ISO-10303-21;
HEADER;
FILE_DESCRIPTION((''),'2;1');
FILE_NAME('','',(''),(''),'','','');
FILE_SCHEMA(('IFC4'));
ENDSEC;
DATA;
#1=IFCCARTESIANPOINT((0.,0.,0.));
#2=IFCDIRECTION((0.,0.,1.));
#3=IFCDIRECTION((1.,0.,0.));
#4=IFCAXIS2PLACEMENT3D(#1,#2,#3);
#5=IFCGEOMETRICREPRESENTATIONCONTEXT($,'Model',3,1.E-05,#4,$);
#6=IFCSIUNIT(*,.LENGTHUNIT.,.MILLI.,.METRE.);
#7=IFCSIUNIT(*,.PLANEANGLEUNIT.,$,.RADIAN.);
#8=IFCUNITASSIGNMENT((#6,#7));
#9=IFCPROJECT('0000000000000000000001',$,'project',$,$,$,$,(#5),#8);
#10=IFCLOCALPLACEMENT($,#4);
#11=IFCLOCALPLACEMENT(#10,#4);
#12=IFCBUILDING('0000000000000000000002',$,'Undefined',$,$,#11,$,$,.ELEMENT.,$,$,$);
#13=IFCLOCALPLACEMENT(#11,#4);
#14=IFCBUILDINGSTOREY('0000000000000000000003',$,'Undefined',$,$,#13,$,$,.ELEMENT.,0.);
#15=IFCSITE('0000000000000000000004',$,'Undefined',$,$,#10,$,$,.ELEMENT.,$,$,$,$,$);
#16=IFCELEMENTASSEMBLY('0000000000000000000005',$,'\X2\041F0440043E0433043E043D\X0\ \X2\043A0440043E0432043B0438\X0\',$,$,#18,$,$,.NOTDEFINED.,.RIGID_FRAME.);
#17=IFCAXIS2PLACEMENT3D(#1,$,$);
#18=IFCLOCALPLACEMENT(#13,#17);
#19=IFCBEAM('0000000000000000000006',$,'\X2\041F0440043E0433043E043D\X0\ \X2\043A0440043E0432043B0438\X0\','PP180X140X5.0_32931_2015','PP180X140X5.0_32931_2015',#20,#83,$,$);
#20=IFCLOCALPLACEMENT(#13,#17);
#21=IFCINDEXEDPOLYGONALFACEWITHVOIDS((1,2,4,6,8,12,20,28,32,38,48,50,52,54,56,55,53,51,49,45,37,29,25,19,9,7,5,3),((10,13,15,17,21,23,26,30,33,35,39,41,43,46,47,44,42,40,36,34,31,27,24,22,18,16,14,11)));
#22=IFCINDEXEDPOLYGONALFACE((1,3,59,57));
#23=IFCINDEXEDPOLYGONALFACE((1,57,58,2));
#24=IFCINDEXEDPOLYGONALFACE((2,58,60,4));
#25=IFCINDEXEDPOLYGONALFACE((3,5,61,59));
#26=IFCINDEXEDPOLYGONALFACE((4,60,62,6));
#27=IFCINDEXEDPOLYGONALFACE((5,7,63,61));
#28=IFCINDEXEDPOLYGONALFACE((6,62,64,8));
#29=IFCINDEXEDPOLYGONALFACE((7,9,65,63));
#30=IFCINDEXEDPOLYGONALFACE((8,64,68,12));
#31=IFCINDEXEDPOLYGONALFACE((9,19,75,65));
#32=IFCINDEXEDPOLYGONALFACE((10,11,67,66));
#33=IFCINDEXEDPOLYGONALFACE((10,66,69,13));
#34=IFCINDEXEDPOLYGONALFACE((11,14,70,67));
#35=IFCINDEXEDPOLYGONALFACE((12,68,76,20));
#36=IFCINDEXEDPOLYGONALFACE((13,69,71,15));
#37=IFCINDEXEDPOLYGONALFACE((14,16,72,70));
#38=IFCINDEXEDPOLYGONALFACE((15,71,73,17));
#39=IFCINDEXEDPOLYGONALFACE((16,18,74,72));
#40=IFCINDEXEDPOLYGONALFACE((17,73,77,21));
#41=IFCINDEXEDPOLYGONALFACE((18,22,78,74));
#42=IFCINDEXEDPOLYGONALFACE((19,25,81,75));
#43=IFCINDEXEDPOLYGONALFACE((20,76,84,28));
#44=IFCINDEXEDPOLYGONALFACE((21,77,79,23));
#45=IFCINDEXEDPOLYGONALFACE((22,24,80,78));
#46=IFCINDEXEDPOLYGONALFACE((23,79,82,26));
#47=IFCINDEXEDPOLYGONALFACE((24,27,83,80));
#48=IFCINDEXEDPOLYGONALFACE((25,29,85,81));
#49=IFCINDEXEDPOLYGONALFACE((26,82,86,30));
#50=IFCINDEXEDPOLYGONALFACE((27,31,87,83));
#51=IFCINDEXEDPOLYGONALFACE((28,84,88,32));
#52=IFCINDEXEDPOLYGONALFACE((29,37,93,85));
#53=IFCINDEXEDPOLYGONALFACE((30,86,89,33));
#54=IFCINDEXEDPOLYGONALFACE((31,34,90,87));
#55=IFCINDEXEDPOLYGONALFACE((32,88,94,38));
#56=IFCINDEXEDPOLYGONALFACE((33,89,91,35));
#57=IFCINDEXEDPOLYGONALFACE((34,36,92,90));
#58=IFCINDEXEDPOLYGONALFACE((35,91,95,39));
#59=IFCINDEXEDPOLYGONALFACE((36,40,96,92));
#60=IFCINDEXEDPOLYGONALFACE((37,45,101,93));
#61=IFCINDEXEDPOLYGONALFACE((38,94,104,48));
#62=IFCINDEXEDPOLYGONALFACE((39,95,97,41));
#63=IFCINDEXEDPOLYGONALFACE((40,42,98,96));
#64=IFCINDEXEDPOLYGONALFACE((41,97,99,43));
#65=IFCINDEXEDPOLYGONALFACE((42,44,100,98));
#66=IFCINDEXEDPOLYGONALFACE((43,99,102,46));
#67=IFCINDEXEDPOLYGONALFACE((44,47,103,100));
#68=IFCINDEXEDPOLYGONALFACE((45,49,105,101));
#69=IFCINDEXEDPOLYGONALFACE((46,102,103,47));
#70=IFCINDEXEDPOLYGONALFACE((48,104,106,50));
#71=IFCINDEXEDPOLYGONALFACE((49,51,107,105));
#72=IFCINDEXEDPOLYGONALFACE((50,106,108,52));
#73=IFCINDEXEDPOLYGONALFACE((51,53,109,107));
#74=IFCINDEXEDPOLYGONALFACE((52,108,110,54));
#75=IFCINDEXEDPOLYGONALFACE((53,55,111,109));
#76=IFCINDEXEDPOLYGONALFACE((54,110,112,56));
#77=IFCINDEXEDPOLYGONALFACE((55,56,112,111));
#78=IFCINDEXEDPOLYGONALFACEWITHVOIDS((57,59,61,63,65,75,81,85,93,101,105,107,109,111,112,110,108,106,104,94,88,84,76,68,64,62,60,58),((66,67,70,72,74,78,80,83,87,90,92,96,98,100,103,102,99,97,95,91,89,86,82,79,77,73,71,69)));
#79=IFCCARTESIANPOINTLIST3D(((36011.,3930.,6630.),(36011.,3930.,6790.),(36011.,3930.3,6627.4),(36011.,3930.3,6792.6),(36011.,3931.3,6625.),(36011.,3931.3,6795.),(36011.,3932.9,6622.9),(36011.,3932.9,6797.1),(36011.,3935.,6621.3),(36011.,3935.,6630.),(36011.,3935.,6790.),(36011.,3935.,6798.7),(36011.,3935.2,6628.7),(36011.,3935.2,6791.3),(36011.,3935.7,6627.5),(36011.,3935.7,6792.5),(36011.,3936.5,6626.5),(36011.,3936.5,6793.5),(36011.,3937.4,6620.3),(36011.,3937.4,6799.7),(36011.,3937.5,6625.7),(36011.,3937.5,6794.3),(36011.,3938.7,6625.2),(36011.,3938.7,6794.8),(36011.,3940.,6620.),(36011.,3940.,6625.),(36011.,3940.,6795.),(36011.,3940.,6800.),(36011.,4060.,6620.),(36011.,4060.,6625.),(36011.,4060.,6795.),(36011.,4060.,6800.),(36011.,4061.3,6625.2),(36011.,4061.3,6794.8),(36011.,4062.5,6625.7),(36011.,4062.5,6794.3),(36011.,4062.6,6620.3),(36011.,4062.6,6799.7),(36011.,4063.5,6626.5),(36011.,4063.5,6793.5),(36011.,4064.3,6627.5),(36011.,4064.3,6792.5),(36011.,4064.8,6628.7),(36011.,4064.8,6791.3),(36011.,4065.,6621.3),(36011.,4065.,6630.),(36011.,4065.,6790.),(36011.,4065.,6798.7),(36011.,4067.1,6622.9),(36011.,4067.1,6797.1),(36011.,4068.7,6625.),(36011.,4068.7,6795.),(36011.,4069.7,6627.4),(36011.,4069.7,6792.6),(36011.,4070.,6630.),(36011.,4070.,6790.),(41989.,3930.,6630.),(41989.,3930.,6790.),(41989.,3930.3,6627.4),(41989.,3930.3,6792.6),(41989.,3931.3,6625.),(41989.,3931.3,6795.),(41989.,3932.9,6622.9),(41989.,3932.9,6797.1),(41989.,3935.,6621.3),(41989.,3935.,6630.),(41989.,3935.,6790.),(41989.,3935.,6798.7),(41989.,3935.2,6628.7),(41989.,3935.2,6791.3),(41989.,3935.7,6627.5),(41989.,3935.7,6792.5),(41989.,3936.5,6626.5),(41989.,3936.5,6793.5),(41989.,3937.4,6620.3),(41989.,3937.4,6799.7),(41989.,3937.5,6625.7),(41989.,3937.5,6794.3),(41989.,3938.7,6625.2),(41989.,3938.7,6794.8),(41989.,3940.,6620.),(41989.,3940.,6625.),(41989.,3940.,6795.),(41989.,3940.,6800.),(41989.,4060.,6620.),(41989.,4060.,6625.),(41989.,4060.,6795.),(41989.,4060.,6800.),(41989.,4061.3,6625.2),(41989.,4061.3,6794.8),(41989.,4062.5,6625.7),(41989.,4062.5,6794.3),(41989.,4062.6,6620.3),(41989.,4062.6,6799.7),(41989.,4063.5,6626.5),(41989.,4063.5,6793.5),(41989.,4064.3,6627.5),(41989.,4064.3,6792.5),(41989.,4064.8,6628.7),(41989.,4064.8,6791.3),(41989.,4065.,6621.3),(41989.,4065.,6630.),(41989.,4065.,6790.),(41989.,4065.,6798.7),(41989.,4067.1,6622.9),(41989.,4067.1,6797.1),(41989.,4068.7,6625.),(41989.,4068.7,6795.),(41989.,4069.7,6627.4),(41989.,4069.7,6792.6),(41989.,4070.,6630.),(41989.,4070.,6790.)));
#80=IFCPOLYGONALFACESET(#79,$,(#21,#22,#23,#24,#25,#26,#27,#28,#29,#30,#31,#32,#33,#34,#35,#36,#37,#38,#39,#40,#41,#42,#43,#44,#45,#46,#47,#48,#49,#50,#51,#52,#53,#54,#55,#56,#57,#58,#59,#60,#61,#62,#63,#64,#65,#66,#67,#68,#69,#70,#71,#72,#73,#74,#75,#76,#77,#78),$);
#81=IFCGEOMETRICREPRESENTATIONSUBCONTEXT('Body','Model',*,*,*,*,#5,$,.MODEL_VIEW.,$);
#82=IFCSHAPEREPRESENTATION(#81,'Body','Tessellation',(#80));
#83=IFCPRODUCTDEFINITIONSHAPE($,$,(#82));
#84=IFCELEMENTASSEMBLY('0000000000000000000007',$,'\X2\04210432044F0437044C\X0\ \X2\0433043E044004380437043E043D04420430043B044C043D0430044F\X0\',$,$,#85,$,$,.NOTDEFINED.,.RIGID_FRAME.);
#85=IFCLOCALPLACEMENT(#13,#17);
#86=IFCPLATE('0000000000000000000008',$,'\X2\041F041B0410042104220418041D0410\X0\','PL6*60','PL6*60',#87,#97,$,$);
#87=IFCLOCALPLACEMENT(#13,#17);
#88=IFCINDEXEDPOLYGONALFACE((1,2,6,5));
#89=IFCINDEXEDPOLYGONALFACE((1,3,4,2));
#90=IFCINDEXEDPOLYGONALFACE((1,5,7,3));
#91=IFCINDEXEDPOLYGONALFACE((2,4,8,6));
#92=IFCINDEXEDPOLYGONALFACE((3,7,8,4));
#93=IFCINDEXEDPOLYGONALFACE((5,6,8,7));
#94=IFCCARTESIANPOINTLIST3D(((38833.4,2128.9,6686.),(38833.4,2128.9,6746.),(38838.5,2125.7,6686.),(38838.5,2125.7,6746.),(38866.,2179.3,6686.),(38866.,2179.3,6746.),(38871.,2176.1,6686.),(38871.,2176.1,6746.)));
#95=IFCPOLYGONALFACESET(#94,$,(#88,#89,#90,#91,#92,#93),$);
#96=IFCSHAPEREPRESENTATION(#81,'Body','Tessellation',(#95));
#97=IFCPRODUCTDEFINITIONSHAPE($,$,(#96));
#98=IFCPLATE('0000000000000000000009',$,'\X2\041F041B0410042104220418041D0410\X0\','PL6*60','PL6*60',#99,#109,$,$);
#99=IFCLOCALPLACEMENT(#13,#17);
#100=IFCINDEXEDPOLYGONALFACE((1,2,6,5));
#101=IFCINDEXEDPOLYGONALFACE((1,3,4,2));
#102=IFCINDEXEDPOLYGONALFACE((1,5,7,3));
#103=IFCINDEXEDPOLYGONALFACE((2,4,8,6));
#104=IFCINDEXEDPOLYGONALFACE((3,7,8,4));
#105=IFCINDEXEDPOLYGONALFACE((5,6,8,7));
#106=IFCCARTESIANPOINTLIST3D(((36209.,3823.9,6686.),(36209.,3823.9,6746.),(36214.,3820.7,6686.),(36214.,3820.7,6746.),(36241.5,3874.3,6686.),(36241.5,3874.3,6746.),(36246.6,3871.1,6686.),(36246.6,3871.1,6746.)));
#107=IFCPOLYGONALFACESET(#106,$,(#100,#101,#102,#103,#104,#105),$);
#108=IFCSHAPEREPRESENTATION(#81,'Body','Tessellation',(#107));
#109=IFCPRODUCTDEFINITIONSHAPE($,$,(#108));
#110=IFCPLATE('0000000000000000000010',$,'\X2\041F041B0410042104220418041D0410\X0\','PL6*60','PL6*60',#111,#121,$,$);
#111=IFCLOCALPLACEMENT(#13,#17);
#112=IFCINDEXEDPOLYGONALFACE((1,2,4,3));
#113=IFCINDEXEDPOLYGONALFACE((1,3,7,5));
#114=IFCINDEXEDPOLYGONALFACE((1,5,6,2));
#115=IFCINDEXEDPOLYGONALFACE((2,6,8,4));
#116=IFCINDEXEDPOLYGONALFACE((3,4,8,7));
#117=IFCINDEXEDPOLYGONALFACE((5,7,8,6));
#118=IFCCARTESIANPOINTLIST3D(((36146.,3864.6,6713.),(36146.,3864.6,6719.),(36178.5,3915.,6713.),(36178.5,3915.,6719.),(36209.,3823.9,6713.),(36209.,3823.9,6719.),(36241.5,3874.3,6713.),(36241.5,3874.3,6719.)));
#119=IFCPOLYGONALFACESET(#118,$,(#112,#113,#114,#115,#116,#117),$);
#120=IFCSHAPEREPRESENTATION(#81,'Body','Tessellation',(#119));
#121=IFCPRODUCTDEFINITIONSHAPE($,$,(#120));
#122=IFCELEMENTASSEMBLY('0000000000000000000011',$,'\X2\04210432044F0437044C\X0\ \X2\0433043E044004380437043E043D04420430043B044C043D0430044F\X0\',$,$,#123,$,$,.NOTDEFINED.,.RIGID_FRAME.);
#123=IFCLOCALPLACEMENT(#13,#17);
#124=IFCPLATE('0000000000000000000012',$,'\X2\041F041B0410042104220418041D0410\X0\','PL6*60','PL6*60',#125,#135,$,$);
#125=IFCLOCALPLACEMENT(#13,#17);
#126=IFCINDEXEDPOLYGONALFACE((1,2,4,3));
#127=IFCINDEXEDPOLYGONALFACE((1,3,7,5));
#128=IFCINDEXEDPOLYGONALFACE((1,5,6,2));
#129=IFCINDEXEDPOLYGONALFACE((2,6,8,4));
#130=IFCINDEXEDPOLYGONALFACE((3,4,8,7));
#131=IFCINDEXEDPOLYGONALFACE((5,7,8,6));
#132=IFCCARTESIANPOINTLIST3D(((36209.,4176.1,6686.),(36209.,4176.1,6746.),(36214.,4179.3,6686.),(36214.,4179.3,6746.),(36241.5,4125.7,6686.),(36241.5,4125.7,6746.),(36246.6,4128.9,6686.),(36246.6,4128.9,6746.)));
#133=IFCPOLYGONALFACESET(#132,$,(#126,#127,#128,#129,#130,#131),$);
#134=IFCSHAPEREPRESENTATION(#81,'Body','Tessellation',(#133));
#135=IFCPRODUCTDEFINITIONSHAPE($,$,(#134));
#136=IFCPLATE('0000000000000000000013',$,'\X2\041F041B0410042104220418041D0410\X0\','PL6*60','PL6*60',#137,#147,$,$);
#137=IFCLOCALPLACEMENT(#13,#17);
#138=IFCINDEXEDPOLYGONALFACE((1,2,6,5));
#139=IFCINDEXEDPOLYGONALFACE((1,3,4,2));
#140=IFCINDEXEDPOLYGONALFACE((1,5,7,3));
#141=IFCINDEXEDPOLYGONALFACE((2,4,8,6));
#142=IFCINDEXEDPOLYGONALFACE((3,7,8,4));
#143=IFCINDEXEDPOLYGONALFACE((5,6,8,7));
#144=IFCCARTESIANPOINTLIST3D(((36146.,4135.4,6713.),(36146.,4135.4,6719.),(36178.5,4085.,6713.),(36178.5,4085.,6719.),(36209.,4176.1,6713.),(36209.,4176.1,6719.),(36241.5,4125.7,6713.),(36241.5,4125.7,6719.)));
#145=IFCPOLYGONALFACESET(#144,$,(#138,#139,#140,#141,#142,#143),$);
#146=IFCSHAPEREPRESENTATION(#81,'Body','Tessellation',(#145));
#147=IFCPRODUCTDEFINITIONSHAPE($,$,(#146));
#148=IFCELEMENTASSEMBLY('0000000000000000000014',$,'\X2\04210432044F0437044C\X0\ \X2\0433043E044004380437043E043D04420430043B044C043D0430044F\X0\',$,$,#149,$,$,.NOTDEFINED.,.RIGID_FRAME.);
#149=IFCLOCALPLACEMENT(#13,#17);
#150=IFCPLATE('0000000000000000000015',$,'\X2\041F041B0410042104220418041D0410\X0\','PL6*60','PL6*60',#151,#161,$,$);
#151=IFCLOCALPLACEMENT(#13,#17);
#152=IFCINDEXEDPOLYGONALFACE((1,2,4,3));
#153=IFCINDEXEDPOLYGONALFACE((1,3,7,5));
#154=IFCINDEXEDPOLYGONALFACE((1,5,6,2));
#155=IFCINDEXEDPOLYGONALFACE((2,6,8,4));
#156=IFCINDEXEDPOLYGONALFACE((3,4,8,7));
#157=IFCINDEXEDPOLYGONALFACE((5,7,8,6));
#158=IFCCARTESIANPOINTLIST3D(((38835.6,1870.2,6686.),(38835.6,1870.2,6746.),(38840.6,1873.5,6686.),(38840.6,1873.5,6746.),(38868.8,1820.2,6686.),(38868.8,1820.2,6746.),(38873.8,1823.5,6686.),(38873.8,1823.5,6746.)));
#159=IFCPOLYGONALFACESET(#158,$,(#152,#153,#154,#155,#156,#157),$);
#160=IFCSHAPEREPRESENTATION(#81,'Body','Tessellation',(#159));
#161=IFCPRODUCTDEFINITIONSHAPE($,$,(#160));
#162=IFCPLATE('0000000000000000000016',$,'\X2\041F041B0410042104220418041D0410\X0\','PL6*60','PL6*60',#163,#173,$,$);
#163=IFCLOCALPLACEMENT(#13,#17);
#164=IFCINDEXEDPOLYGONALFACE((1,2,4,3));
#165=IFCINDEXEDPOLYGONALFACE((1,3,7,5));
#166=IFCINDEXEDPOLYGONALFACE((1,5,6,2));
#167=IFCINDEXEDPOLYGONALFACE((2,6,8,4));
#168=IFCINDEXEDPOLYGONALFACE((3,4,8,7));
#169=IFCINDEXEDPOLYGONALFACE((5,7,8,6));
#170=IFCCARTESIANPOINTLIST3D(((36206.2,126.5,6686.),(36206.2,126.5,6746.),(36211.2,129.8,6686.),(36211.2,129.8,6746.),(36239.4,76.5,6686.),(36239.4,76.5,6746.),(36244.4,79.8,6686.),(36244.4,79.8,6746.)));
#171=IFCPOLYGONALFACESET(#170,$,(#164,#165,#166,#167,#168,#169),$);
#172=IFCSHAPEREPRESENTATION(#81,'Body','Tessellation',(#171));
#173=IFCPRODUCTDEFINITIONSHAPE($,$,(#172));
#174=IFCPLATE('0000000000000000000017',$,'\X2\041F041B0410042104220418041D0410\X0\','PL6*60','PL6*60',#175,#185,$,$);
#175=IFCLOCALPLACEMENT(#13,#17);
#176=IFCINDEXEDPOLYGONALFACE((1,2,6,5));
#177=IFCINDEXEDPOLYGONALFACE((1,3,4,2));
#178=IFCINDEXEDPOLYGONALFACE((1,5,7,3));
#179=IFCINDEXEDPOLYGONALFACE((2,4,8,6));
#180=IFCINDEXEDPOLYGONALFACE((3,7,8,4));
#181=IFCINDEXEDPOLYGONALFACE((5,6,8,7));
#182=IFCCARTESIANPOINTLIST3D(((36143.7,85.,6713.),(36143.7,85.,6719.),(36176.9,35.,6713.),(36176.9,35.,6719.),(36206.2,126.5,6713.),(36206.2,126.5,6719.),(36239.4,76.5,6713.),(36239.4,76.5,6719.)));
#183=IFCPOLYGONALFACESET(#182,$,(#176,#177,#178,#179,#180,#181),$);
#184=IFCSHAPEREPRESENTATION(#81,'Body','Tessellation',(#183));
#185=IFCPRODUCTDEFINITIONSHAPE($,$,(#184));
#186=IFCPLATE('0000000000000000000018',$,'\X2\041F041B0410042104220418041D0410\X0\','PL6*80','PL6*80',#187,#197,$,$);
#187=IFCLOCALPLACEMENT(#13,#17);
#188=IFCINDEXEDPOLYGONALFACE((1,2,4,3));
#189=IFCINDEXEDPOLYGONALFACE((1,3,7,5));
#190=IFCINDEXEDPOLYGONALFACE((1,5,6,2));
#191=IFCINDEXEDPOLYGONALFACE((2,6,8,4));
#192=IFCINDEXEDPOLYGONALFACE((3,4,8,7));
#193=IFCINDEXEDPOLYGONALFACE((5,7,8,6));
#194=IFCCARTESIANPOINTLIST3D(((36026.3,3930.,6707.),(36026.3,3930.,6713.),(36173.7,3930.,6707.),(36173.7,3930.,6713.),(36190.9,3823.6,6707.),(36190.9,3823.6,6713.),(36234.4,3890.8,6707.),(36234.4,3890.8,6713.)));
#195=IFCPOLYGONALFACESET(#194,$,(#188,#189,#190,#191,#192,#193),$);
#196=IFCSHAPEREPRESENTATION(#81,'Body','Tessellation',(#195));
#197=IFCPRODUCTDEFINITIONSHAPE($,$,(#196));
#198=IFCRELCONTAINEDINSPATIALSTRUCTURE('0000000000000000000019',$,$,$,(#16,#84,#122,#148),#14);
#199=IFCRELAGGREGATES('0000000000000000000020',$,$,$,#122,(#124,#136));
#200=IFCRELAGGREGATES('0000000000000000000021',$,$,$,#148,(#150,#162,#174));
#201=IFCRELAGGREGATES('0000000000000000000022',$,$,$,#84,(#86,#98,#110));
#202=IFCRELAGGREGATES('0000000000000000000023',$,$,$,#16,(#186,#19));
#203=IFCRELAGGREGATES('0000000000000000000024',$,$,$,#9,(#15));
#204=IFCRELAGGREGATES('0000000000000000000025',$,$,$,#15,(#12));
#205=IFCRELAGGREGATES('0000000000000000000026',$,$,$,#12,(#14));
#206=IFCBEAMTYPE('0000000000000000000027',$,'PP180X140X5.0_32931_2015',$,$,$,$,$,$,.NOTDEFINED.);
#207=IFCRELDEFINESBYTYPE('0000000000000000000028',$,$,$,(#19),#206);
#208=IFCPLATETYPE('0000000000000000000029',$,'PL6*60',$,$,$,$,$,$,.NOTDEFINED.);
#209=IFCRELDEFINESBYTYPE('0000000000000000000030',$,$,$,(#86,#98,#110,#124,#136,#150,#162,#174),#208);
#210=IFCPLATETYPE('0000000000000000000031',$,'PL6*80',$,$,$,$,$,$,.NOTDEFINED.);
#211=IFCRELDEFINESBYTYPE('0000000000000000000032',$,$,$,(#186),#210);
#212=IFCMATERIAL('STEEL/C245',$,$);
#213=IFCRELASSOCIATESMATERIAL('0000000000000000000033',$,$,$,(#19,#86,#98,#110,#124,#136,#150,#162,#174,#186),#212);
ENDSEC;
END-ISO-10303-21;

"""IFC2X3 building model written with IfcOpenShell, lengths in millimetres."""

from ifc_helpers import new_model, si_unit, frame, origin_with_axes, origin_2d_with_axis, place, context, subcontext, project, spatial, polyline, hollow_rectangle, outline, extrude, clip, halfspace, material, type_object, element, aggregate, save


model = new_model("IFC2X3")

# Units and contexts
model_context = context("Model", 3, precision=1e-05, world=origin_with_axes())
body_context = subcontext(model_context, "Body", "Model", "MODEL_VIEW")
ifc_project = project(units=[si_unit("LENGTHUNIT", "METRE", prefix="MILLI"), si_unit("PLANEANGLEUNIT", "RADIAN")], contexts=[model_context])

# Site, building, storey
site_placement = place(None, origin_with_axes())
site = spatial("IfcSite", under=ifc_project, at=site_placement, Name="Undefined", CompositionType="ELEMENT")
building_placement = place(site_placement, origin_with_axes())
building = spatial("IfcBuilding", under=site, at=building_placement, Name="Undefined", CompositionType="ELEMENT")
storey_placement = place(building_placement, origin_with_axes())
storey = spatial("IfcBuildingStorey", under=building, at=storey_placement, Name="Undefined", CompositionType="ELEMENT", Elevation=0.0)

# Shared definitions
ifc_material_1 = material(Name="STEEL/C245")

# Element assembly
assembly_1_placement = place(storey_placement, origin_with_axes())
assembly_1 = element("IfcElementAssembly", 1, at=assembly_1_placement, inside=storey, Name="Прогон кровли", AssemblyPlace="NOTDEFINED", PredefinedType="RIGID_FRAME")

# Beam
beam_type_1 = type_object("IfcBeamType", Name="PP180X140X5.0_32931_2015", PredefinedType="NOTDEFINED")
beam_1_placement = place(assembly_1_placement, frame((36005.0, 4000.0, 6710.0), z_axis=(0.0, 0.0, 1.0), x_axis=(1.0, 0.0, 0.0)))
beam_1 = element("IfcBeam", 2, at=beam_1_placement, type_object=beam_type_1, material=ifc_material_1, Name="Прогон кровли", Description="PP180X140X5.0_32931_2015", ObjectType="PP180X140X5.0_32931_2015", context=body_context, shape_type="Clipping", body=[
    clip(clip(extrude(hollow_rectangle(XDim=140.0, YDim=180.0, WallThickness=5.0, InnerFilletRadius=5.0, OuterFilletRadius=10.0, at=origin_2d_with_axis()), frame((5984.0, 0.0, 0.0), z_axis=(-1.0, 0.0, 0.0), x_axis=(0.0, -1.0, 0.0)), (0.0, 0.0, 1.0), 5978.0), halfspace(frame((5984.0, 0.0, -90.0), z_axis=(-1.0, 0.0, 0.0), x_axis=(0.0, 1.0, 0.0)), True)), halfspace(frame((6.0, 0.0, -90.0), z_axis=(1.0, 0.0, 0.0), x_axis=(0.0, -1.0, 0.0)), True)),
])

# Element assemblies, plates
assembly_2_placement = place(storey_placement, origin_with_axes())
assembly_2 = element("IfcElementAssembly", 3, at=assembly_2_placement, inside=storey, Name="Связь горизонтальная", AssemblyPlace="NOTDEFINED", PredefinedType="RIGID_FRAME")
plate_type_1 = type_object("IfcPlateType", Name="PL6*60", PredefinedType="NOTDEFINED")
plate_1_placement = place(assembly_2_placement, frame((38852.2, 2152.5, 6686.0), z_axis=(0.840039, -0.542525, 0.0), x_axis=(0.0, 0.0, 1.0)))
plate_1 = element("IfcPlate", 4, at=plate_1_placement, type_object=plate_type_1, material=ifc_material_1, Name="ПЛАСТИНА", Description="PL6*60", ObjectType="PL6*60", context=body_context, shape_type="SweptSolid", body=[
    extrude(outline(polyline([(0.0, 30.0), (60.0, 30.0), (60.0, -30.0), (0.0, -30.0), (0.0, 30.0)])), frame((0.0, 0.0, -3.0), z_axis=(0.0, 0.0, 1.0), x_axis=(1.0, 0.0, 0.0)), (0.0, 0.0, 1.0), 6.0),
])
plate_2_placement = place(assembly_2_placement, frame((36227.8, 3847.5, 6746.0), z_axis=(-0.840039, 0.542525, 0.0), x_axis=(0.0, 0.0, -1.0)))
plate_2 = element("IfcPlate", 5, at=plate_2_placement, type_object=plate_type_1, material=ifc_material_1, Name="ПЛАСТИНА", Description="PL6*60", ObjectType="PL6*60", context=body_context, shape_type="SweptSolid", body=[
    extrude(outline(polyline([(60.0, 30.0), (60.0, -30.0), (0.0, -30.0), (0.0, 30.0), (60.0, 30.0)])), frame((0.0, 0.0, -3.0), z_axis=(0.0, 0.0, 1.0), x_axis=(1.0, 0.0, 0.0)), (0.0, 0.0, 1.0), 6.0),
])
plate_3_placement = place(assembly_2_placement, frame((36162.2, 3889.8, 6716.0), z_axis=(0.0, 0.0, 1.0), x_axis=(0.840039, -0.542525, 0.0)))
plate_3 = element("IfcPlate", 6, at=plate_3_placement, type_object=plate_type_1, material=ifc_material_1, Name="ПЛАСТИНА", Description="PL6*60", ObjectType="PL6*60", context=body_context, shape_type="SweptSolid", body=[
    extrude(outline(polyline([(0.0, -30.0), (0.0, 30.0), (75.0, 30.0), (75.0, -30.0), (0.0, -30.0)])), frame((0.0, 0.0, -3.0), z_axis=(0.0, 0.0, 1.0), x_axis=(1.0, 0.0, 0.0)), (0.0, 0.0, 1.0), 6.0),
])
assembly_3_placement = place(storey_placement, origin_with_axes())
assembly_3 = element("IfcElementAssembly", 7, at=assembly_3_placement, inside=storey, Name="Связь горизонтальная", AssemblyPlace="NOTDEFINED", PredefinedType="RIGID_FRAME")
plate_4_placement = place(assembly_3_placement, frame((36227.8, 4152.5, 6686.0), z_axis=(-0.840039, -0.542525, 0.0), x_axis=(0.0, 0.0, 1.0)))
plate_4 = element("IfcPlate", 8, at=plate_4_placement, type_object=plate_type_1, material=ifc_material_1, Name="ПЛАСТИНА", Description="PL6*60", ObjectType="PL6*60", context=body_context, shape_type="SweptSolid", body=[
    extrude(outline(polyline([(0.0, 30.0), (60.0, 30.0), (60.0, -30.0), (0.0, -30.0), (0.0, 30.0)])), frame((0.0, 0.0, -3.0), z_axis=(0.0, 0.0, 1.0), x_axis=(1.0, 0.0, 0.0)), (0.0, 0.0, 1.0), 6.0),
])
plate_5_placement = place(assembly_3_placement, frame((36162.2, 4110.2, 6716.0), z_axis=(0.0, 0.0, -1.0), x_axis=(0.840039, 0.542525, 0.0)))
plate_5 = element("IfcPlate", 9, at=plate_5_placement, type_object=plate_type_1, material=ifc_material_1, Name="ПЛАСТИНА", Description="PL6*60", ObjectType="PL6*60", context=body_context, shape_type="SweptSolid", body=[
    extrude(outline(polyline([(0.0, -30.0), (0.0, 30.0), (75.0, 30.0), (75.0, -30.0), (0.0, -30.0)])), frame((0.0, 0.0, -3.0), z_axis=(0.0, 0.0, 1.0), x_axis=(1.0, 0.0, 0.0)), (0.0, 0.0, 1.0), 6.0),
])
assembly_4_placement = place(storey_placement, origin_with_axes())
assembly_4 = element("IfcElementAssembly", 10, at=assembly_4_placement, inside=storey, Name="Связь горизонтальная", AssemblyPlace="NOTDEFINED", PredefinedType="RIGID_FRAME")
plate_6_placement = place(assembly_4_placement, frame((38854.7, 1846.9, 6686.0), z_axis=(0.833383, 0.552695, 0.0), x_axis=(0.0, 0.0, 1.0)))
plate_6 = element("IfcPlate", 11, at=plate_6_placement, type_object=plate_type_1, material=ifc_material_1, Name="ПЛАСТИНА", Description="PL6*60", ObjectType="PL6*60", context=body_context, shape_type="SweptSolid", body=[
    extrude(outline(polyline([(0.0, -30.0), (0.0, 30.0), (60.0, 30.0), (60.0, -30.0), (0.0, -30.0)])), frame((0.0, 0.0, -3.0), z_axis=(0.0, 0.0, 1.0), x_axis=(1.0, 0.0, 0.0)), (0.0, 0.0, 1.0), 6.0),
])
plate_7_placement = place(assembly_4_placement, frame((36225.3, 103.1, 6686.0), z_axis=(-0.833383, -0.552695, 0.0), x_axis=(0.0, 0.0, 1.0)))
plate_7 = element("IfcPlate", 12, at=plate_7_placement, type_object=plate_type_1, material=ifc_material_1, Name="ПЛАСТИНА", Description="PL6*60", ObjectType="PL6*60", context=body_context, shape_type="SweptSolid", body=[
    extrude(outline(polyline([(0.0, 30.0), (60.0, 30.0), (60.0, -30.0), (0.0, -30.0), (0.0, 30.0)])), frame((0.0, 0.0, -3.0), z_axis=(0.0, 0.0, 1.0), x_axis=(1.0, 0.0, 0.0)), (0.0, 0.0, 1.0), 6.0),
])
plate_8_placement = place(assembly_4_placement, frame((36160.3, 60.0, 6716.0), z_axis=(0.0, 0.0, -1.0), x_axis=(0.833383, 0.552695, 0.0)))
plate_8 = element("IfcPlate", 13, at=plate_8_placement, type_object=plate_type_1, material=ifc_material_1, Name="ПЛАСТИНА", Description="PL6*60", ObjectType="PL6*60", context=body_context, shape_type="SweptSolid", body=[
    extrude(outline(polyline([(0.0, -30.0), (0.0, 30.0), (75.0, 30.0), (75.0, -30.0), (0.0, -30.0)])), frame((0.0, 0.0, -3.0), z_axis=(0.0, 0.0, 1.0), x_axis=(1.0, 0.0, 0.0)), (0.0, 0.0, 1.0), 6.0),
])

# Plate
plate_type_2 = type_object("IfcPlateType", Name="PL6*80", PredefinedType="NOTDEFINED")
plate_9_placement = place(assembly_1_placement, frame((36026.3, 3930.0, 6710.0), z_axis=(0.0, 0.0, 1.0), x_axis=(0.840039, -0.542525, 0.0)))
plate_9 = element("IfcPlate", 14, at=plate_9_placement, type_object=plate_type_2, material=ifc_material_1, Name="ПЛАСТИНА", Description="PL6*80", ObjectType="PL6*80", context=body_context, shape_type="SweptSolid", body=[
    extrude(outline(polyline([(0.0, 0.0), (196.0, 0.0), (196.0, 80.0), (123.9, 80.0), (0.0, 0.0)])), frame((0.0, 0.0, -3.0), z_axis=(0.0, 0.0, 1.0), x_axis=(1.0, 0.0, 0.0)), (0.0, 0.0, 1.0), 6.0),
])

aggregate(assembly_3, [plate_4, plate_5])
aggregate(assembly_4, [plate_6, plate_7, plate_8])
aggregate(assembly_2, [plate_1, plate_2, plate_3])
aggregate(assembly_1, [plate_9, beam_1])

save(model, "model.ifc")
